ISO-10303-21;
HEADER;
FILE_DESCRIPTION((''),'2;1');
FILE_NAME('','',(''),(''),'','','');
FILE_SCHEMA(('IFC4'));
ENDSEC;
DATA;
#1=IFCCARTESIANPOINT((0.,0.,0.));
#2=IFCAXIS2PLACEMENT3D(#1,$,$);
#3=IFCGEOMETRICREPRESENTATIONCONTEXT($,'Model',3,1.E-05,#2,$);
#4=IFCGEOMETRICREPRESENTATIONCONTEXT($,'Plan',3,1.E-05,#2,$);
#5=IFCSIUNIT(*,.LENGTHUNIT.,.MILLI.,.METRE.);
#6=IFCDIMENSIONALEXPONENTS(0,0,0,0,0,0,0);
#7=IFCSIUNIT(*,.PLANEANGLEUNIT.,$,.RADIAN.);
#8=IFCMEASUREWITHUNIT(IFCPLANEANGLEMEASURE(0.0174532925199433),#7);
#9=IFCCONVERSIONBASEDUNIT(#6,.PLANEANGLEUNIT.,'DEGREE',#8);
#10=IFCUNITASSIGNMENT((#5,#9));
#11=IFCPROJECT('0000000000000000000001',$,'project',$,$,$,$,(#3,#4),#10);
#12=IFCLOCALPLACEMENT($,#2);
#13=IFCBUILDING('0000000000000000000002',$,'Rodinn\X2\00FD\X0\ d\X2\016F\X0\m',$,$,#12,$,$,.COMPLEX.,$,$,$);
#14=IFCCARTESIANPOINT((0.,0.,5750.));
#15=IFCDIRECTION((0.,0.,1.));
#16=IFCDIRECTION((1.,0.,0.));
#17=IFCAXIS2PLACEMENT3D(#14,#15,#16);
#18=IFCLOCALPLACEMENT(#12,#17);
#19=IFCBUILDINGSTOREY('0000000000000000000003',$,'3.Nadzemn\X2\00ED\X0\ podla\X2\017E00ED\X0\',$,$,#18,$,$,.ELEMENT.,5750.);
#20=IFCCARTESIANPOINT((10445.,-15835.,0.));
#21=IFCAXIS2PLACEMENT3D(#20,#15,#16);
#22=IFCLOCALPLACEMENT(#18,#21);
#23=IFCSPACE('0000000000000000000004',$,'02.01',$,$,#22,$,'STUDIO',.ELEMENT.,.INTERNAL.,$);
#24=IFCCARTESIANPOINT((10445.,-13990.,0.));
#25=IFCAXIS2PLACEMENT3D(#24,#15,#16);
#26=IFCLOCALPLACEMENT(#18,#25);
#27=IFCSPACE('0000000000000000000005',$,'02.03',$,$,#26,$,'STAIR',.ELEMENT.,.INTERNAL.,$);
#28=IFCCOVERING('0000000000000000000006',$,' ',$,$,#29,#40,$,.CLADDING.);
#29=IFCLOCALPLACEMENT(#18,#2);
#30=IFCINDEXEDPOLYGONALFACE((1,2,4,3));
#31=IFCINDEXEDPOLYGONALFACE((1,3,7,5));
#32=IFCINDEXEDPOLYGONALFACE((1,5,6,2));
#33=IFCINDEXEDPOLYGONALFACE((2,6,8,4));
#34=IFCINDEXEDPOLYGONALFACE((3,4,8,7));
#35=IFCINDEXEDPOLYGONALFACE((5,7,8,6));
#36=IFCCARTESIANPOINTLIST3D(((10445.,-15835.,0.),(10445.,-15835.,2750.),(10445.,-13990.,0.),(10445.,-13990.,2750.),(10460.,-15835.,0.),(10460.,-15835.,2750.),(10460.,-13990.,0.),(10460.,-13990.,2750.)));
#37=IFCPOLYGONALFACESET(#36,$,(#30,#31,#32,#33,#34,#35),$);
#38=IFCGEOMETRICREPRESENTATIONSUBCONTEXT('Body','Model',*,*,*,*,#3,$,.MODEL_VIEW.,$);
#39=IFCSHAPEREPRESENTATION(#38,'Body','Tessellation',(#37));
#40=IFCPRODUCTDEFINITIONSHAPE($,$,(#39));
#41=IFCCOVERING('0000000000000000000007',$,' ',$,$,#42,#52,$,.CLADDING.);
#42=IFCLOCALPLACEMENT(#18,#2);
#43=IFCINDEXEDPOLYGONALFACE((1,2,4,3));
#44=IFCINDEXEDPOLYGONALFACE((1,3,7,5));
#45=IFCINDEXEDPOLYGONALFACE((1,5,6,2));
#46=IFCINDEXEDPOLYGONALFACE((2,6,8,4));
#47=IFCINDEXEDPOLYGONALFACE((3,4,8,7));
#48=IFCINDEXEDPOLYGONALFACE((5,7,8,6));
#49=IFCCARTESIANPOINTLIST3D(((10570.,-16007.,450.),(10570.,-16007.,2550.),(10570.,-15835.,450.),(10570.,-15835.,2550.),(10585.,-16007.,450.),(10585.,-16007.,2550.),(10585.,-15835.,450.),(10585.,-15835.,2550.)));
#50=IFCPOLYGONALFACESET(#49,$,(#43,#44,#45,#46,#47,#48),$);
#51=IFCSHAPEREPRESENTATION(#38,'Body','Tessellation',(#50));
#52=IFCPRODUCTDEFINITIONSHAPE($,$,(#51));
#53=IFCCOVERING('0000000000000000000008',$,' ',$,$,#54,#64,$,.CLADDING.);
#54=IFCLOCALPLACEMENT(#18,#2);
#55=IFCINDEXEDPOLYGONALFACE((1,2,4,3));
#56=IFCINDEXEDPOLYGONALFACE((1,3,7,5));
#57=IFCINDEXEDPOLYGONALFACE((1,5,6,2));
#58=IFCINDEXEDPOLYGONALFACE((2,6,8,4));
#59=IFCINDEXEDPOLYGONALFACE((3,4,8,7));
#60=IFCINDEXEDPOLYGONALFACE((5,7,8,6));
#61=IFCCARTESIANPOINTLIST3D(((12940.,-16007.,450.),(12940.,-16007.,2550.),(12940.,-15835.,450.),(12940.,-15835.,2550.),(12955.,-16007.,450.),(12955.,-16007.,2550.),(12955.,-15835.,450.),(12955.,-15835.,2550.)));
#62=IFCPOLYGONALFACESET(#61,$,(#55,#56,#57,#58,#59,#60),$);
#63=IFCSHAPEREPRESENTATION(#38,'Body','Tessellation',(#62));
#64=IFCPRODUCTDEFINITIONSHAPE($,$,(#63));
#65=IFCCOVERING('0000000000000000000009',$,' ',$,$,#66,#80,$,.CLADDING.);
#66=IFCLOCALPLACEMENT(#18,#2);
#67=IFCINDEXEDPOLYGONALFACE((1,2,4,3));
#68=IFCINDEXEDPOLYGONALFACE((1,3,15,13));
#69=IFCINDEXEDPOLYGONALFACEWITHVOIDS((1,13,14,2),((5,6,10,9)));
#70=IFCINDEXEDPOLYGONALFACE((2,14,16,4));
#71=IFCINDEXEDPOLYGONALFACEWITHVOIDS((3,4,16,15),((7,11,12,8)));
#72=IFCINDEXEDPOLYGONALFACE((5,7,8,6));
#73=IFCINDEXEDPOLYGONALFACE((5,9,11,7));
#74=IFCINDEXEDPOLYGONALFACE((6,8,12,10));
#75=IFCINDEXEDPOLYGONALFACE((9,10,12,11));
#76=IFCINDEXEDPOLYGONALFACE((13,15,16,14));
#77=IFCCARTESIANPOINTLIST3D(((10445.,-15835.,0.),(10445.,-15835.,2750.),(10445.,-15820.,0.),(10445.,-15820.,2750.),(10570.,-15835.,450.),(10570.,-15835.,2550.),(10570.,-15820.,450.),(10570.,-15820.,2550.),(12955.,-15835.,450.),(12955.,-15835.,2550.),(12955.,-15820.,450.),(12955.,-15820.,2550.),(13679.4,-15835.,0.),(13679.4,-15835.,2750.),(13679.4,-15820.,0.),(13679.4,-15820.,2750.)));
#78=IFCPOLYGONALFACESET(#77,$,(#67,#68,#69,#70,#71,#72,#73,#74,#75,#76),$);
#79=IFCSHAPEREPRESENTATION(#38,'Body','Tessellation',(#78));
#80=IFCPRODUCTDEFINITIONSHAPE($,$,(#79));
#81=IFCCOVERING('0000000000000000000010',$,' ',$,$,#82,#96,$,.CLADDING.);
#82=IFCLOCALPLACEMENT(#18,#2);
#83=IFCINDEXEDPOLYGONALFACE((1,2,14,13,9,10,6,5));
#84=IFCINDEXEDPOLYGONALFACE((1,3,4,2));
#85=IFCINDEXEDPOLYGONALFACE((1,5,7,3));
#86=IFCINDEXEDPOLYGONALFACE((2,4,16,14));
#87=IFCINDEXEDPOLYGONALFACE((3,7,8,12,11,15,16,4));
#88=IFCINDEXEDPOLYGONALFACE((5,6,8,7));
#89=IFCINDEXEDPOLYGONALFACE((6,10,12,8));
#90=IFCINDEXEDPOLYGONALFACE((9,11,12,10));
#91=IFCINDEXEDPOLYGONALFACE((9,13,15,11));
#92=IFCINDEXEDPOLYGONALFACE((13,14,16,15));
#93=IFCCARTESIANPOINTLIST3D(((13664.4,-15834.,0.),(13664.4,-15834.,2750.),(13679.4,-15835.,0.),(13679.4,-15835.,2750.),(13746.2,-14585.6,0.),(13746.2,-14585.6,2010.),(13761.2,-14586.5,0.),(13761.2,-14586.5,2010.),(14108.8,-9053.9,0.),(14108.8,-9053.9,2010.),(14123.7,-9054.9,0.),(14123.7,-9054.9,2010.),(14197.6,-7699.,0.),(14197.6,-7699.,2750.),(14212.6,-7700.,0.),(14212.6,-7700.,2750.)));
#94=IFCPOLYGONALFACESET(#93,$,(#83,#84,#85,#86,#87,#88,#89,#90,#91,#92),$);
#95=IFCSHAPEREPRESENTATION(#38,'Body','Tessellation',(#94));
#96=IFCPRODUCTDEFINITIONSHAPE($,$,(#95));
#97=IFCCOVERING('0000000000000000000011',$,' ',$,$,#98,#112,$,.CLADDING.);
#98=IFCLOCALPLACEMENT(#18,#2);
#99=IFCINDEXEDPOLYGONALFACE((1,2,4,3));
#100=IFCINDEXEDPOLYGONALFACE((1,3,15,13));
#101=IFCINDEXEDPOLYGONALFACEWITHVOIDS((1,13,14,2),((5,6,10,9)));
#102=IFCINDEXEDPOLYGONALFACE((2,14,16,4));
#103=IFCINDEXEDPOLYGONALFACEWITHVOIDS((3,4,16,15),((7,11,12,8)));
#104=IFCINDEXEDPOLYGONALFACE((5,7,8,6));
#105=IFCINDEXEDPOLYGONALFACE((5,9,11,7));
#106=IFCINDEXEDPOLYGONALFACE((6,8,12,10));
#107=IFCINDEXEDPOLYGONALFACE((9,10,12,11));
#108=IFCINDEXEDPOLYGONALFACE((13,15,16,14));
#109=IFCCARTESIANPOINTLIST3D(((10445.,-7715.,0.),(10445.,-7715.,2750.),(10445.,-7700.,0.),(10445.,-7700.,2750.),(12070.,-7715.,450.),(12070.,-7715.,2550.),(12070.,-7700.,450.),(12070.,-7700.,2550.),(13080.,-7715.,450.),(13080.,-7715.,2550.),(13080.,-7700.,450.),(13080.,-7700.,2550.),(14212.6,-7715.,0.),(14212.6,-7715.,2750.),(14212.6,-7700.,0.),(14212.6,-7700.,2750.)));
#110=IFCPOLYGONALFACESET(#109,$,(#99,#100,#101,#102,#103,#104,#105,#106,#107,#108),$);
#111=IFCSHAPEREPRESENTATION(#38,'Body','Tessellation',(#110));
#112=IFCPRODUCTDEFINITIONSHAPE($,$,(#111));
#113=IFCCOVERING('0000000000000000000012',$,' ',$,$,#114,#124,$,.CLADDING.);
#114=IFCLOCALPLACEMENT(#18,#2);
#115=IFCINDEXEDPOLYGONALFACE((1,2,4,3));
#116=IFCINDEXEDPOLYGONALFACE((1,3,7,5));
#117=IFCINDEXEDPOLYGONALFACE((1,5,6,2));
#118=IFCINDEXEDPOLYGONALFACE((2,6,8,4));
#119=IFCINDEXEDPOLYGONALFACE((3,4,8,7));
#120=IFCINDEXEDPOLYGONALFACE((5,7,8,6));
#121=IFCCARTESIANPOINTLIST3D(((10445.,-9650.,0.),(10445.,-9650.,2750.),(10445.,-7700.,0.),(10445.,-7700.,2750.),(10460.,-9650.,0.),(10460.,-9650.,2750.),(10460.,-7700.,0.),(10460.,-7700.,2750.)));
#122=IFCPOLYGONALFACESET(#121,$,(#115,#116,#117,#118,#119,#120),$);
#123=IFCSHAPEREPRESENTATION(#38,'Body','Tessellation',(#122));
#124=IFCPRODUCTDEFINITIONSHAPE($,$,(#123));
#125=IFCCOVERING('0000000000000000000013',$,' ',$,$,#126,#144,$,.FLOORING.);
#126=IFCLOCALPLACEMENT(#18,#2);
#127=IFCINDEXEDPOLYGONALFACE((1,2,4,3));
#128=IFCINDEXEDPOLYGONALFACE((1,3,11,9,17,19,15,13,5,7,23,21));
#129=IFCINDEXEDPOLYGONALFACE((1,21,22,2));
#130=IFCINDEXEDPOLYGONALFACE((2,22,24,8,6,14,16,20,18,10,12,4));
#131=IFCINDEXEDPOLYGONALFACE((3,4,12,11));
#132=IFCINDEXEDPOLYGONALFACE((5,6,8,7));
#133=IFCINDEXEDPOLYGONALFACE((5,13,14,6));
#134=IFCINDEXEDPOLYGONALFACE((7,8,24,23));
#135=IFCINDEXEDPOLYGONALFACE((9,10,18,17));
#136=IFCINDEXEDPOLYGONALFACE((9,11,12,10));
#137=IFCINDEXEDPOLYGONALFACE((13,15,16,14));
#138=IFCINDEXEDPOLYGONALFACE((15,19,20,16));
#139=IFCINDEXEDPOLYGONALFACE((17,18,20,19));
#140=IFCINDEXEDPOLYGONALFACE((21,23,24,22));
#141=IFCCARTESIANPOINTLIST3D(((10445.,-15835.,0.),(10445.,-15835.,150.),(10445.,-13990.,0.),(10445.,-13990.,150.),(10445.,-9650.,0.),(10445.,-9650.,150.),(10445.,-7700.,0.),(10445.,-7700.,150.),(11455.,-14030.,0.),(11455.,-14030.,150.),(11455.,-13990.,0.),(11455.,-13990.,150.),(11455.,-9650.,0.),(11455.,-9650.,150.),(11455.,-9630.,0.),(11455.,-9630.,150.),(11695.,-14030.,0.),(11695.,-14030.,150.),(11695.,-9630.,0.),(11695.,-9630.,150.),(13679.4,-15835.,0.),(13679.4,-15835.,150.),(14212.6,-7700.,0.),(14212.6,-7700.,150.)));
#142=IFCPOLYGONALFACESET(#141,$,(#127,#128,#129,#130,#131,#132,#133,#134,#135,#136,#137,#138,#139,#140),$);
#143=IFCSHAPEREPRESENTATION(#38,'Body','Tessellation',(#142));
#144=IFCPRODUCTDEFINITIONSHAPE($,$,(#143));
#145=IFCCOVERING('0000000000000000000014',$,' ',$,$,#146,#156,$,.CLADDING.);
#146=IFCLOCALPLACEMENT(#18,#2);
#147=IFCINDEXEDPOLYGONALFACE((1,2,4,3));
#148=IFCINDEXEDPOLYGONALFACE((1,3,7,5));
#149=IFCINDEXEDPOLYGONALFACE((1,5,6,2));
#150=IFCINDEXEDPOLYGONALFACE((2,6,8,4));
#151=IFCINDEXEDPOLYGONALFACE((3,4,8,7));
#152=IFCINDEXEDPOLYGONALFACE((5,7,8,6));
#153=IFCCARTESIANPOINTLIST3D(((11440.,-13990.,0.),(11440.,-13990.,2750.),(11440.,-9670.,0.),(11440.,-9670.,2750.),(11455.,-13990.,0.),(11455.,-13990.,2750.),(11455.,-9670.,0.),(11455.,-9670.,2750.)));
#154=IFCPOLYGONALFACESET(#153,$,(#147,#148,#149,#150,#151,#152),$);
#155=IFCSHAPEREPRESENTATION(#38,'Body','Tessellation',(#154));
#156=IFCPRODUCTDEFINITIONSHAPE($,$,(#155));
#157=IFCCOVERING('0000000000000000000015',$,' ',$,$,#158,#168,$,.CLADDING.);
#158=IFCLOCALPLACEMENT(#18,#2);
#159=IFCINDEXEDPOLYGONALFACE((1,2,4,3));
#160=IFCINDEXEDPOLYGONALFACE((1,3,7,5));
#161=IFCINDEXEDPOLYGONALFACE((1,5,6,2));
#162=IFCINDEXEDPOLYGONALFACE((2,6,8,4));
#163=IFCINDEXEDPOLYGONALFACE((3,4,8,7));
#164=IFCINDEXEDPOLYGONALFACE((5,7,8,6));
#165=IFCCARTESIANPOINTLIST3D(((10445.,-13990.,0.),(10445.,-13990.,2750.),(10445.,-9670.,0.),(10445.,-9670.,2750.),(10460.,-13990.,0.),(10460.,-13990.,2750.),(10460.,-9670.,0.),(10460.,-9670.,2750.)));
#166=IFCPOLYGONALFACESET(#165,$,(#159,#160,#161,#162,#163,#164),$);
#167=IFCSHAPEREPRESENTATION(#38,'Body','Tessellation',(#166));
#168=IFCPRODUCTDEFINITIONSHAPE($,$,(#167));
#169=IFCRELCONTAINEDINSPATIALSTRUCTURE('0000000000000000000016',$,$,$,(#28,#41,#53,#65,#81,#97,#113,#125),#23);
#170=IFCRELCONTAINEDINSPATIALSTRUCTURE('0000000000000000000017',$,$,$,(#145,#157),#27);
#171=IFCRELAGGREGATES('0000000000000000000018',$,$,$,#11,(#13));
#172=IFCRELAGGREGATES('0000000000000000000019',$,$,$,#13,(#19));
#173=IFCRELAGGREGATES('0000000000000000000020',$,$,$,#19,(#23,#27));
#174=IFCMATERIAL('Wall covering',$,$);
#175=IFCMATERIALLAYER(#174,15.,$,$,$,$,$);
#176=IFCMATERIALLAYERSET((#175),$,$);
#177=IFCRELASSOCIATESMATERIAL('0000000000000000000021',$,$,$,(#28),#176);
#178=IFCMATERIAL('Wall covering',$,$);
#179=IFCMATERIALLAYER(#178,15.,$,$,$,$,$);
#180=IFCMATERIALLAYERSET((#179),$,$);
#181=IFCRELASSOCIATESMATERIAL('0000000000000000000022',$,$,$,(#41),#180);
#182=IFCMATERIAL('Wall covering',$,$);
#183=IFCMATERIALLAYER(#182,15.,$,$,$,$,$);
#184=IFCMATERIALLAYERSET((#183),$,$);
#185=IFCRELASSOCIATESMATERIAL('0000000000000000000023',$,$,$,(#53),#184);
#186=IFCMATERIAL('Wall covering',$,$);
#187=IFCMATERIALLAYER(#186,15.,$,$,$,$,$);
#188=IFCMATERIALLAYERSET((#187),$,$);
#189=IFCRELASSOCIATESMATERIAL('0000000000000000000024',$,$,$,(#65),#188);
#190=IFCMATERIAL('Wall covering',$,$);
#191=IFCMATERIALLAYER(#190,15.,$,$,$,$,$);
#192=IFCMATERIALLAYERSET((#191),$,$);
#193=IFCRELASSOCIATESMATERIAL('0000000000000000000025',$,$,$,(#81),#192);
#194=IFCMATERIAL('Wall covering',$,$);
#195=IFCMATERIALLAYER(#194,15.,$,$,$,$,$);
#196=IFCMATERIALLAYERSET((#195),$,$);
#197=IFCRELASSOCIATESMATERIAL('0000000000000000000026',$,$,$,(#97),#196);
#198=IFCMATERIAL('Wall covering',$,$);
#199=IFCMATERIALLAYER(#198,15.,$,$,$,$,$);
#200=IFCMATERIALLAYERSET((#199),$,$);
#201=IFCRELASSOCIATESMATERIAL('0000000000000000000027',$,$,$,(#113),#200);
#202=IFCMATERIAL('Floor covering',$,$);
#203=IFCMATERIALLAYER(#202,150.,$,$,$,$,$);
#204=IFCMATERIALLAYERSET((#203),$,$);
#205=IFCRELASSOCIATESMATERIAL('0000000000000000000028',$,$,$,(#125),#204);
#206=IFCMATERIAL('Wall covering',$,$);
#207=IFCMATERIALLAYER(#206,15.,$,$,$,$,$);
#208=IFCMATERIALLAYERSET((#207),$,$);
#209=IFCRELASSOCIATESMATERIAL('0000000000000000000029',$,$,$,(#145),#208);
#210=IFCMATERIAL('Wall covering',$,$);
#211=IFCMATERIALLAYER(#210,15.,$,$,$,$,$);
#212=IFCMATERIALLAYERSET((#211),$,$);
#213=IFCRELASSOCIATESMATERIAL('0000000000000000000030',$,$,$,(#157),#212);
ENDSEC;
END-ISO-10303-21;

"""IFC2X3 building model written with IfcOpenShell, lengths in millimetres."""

from ifc_helpers import new_model, entity, si_unit, converted_unit, frame, frame_2d, origin, origin_with_axes, place, context, subcontext, project, spatial, polyline, rectangle, outline, extrude, material, layer, layer_set, layer_usage, element, save


model = new_model("IFC2X3")

# Units and contexts
model_context = context("Model", 3, precision=1e-05, world=origin())
plan_context = context("Plan", 3, precision=1e-05, world=origin())
body_context = subcontext(model_context, "Body", "Model", "MODEL_VIEW")
ifc_project = project(units=[si_unit("LENGTHUNIT", "METRE", prefix="MILLI"), converted_unit("PLANEANGLEUNIT", "DEGREE", entity("IfcPlaneAngleMeasure", 0.0174532925199433), si_unit("PLANEANGLEUNIT", "RADIAN"), dimensions=[0, 0, 0, 0, 0, 0, 0])], contexts=[model_context, plan_context])

# Building, storey
building_placement = place(None, origin())
building = spatial("IfcBuilding", under=ifc_project, at=building_placement, Name="Rodinný dům", CompositionType="COMPLEX")
storey_placement = place(building_placement, frame((0.0, 0.0, 5750.0), z_axis=(0.0, 0.0, 1.0), x_axis=(1.0, 0.0, 0.0)))
storey = spatial("IfcBuildingStorey", under=building, at=storey_placement, Name="3.Nadzemní podlaží", CompositionType="ELEMENT", Elevation=5750.0)

# Shared definitions
space_1_placement = place(storey_placement, frame((10445.0, -15835.0, 0.0), z_axis=(0.0, 0.0, 1.0), x_axis=(1.0, 0.0, 0.0)))
space_1 = spatial("IfcSpace", under=storey, at=space_1_placement, Name="02.01", LongName="STUDIO", CompositionType="ELEMENT", InteriorOrExteriorSpace="INTERNAL")

# Coverings
ifc_material_1 = material(Name="Wall covering")
ifc_layer_1 = layer(ifc_material_1, 15.0)
ifc_layer_set_1 = layer_set([ifc_layer_1])
ifc_layer_usage_1 = layer_usage(ifc_layer_set_1, "AXIS3", "POSITIVE", 0.0)
covering_1_placement = place(space_1_placement, frame((0.0, 1845.0, 0.0), z_axis=(0.0, 0.0, 1.0), x_axis=(0.0, -1.0, 0.0)))
element("IfcCovering", 1, at=covering_1_placement, inside=space_1, material=ifc_layer_usage_1, Name=" ", PredefinedType="CLADDING", context=body_context, shape_type="SweptSolid", body=[
    extrude(rectangle(XDim=2750.0, YDim=1845.0, at=frame_2d((-922.5, 1375.0), x_axis=(0.0, 1.0))), frame((1845.0, 0.0, 2750.0), z_axis=(0.0, 1.0, 0.0), x_axis=(1.0, 0.0, 0.0)), (0.0, 0.0, 1.0), 15.0),
])
ifc_material_2 = material(Name="Wall covering")
ifc_layer_2 = layer(ifc_material_2, 15.0)
ifc_layer_set_2 = layer_set([ifc_layer_2])
ifc_layer_usage_2 = layer_usage(ifc_layer_set_2, "AXIS3", "POSITIVE", 0.0)
covering_2_placement = place(space_1_placement, frame((125.0, 0.0, 450.0), z_axis=(0.0, 0.0, 1.0), x_axis=(0.0, -1.0, 0.0)))
element("IfcCovering", 2, at=covering_2_placement, inside=space_1, material=ifc_layer_usage_2, Name=" ", PredefinedType="CLADDING", context=body_context, shape_type="SweptSolid", body=[
    extrude(rectangle(XDim=2100.0, YDim=172.0, at=frame_2d((-86.0, 1050.0), x_axis=(0.0, 1.0))), frame((172.0, 0.0, 2100.0), z_axis=(0.0, 1.0, 0.0), x_axis=(1.0, 0.0, 0.0)), (0.0, 0.0, 1.0), 15.0),
])
ifc_material_3 = material(Name="Wall covering")
ifc_layer_3 = layer(ifc_material_3, 15.0)
ifc_layer_set_3 = layer_set([ifc_layer_3])
ifc_layer_usage_3 = layer_usage(ifc_layer_set_3, "AXIS3", "POSITIVE", 0.0)
covering_3_placement = place(space_1_placement, frame((2510.0, -172.0, 450.0), z_axis=(0.0, 0.0, 1.0), x_axis=(0.0, 1.0, 0.0)))
element("IfcCovering", 3, at=covering_3_placement, inside=space_1, material=ifc_layer_usage_3, Name=" ", PredefinedType="CLADDING", context=body_context, shape_type="SweptSolid", body=[
    extrude(rectangle(XDim=2100.0, YDim=172.0, at=frame_2d((-86.0, 1050.0), x_axis=(0.0, 1.0))), frame((172.0, 0.0, 2100.0), z_axis=(0.0, 1.0, 0.0), x_axis=(1.0, 0.0, 0.0)), (0.0, 0.0, 1.0), 15.0),
])
ifc_material_4 = material(Name="Wall covering")
ifc_layer_4 = layer(ifc_material_4, 15.0)
ifc_layer_set_4 = layer_set([ifc_layer_4])
ifc_layer_usage_4 = layer_usage(ifc_layer_set_4, "AXIS3", "POSITIVE", 0.0)
covering_4_placement = place(space_1_placement, origin_with_axes())
element("IfcCovering", 4, at=covering_4_placement, inside=space_1, material=ifc_layer_usage_4, Name=" ", PredefinedType="CLADDING", context=body_context, shape_type="SweptSolid", body=[
    extrude(outline(polyline([(3234.4, 0.0), (3234.4, -2750.0), (0.0, -2750.0), (0.0, 0.0), (3234.4, 0.0)]), holes=[polyline([(2510.0, -450.0), (125.0, -450.0), (125.0, -2550.0), (2510.0, -2550.0), (2510.0, -450.0)])]), frame((0.0, 0.0, 0.0), z_axis=(0.0, 1.0, 0.0), x_axis=(1.0, 0.0, 0.0)), (0.0, 0.0, 1.0), 15.0),
])
ifc_material_5 = material(Name="Wall covering")
ifc_layer_5 = layer(ifc_material_5, 15.0)
ifc_layer_set_5 = layer_set([ifc_layer_5])
ifc_layer_usage_5 = layer_usage(ifc_layer_set_5, "AXIS3", "POSITIVE", 0.0)
covering_5_placement = place(space_1_placement, frame((3234.4, 0.0, 0.0), z_axis=(0.0, 0.0, 1.0), x_axis=(0.065403, 0.997859, 0.0)))
element("IfcCovering", 5, at=covering_5_placement, inside=space_1, material=ifc_layer_usage_5, Name=" ", PredefinedType="CLADDING", context=body_context, shape_type="SweptSolid", body=[
    extrude(outline(polyline([(8152.5, 0.0), (8152.5, -2750.0), (0.0, -2750.0), (0.0, 0.0), (1251.1, 0.0), (1251.1, -2010.0), (6794.6, -2010.0), (6794.6, 0.0), (8152.5, 0.0)])), frame((0.0, 0.0, 0.0), z_axis=(0.0, 1.0, 0.0), x_axis=(1.0, 0.0, 0.0)), (0.0, 0.0, 1.0), 15.0),
])
ifc_material_6 = material(Name="Wall covering")
ifc_layer_6 = layer(ifc_material_6, 15.0)
ifc_layer_set_6 = layer_set([ifc_layer_6])
ifc_layer_usage_6 = layer_usage(ifc_layer_set_6, "AXIS3", "POSITIVE", 0.0)
covering_6_placement = place(space_1_placement, frame((3767.6, 8135.0, 0.0), z_axis=(0.0, 0.0, 1.0), x_axis=(-1.0, 0.0, 0.0)))
element("IfcCovering", 6, at=covering_6_placement, inside=space_1, material=ifc_layer_usage_6, Name=" ", PredefinedType="CLADDING", context=body_context, shape_type="SweptSolid", body=[
    extrude(outline(polyline([(3767.6, 0.0), (3767.6, -2750.0), (0.0, -2750.0), (0.0, 0.0), (3767.6, 0.0)]), holes=[polyline([(2142.6, -450.0), (1132.6, -450.0), (1132.6, -2550.0), (2142.6, -2550.0), (2142.6, -450.0)])]), frame((0.0, 0.0, 0.0), z_axis=(0.0, 1.0, 0.0), x_axis=(1.0, 0.0, 0.0)), (0.0, 0.0, 1.0), 15.0),
])
ifc_material_7 = material(Name="Wall covering")
ifc_layer_7 = layer(ifc_material_7, 15.0)
ifc_layer_set_7 = layer_set([ifc_layer_7])
ifc_layer_usage_7 = layer_usage(ifc_layer_set_7, "AXIS3", "POSITIVE", 0.0)
covering_7_placement = place(space_1_placement, frame((0.0, 8135.0, 0.0), z_axis=(0.0, 0.0, 1.0), x_axis=(0.0, -1.0, 0.0)))
element("IfcCovering", 7, at=covering_7_placement, inside=space_1, material=ifc_layer_usage_7, Name=" ", PredefinedType="CLADDING", context=body_context, shape_type="SweptSolid", body=[
    extrude(rectangle(XDim=2750.0, YDim=1950.0, at=frame_2d((-975.0, 1375.0), x_axis=(0.0, 1.0))), frame((1950.0, 0.0, 2750.0), z_axis=(0.0, 1.0, 0.0), x_axis=(1.0, 0.0, 0.0)), (0.0, 0.0, 1.0), 15.0),
])
ifc_material_8 = material(Name="Floor covering")
ifc_layer_8 = layer(ifc_material_8, 150.0)
ifc_layer_set_8 = layer_set([ifc_layer_8])
ifc_layer_usage_8 = layer_usage(ifc_layer_set_8, "AXIS3", "POSITIVE", 0.0)
covering_8_placement = place(space_1_placement, origin_with_axes())
element("IfcCovering", 8, at=covering_8_placement, inside=space_1, material=ifc_layer_usage_8, Name=" ", PredefinedType="FLOORING", context=body_context, shape_type="SweptSolid", body=[
    extrude(outline(polyline([(1250.0, 6205.0), (1250.0, 1805.0), (1010.0, 1805.0), (1010.0, 1845.0), (0.0, 1845.0), (0.0, 0.0), (3234.4, 0.0), (3767.6, 8135.0), (0.0, 8135.0), (0.0, 6185.0), (1010.0, 6185.0), (1010.0, 6205.0), (1250.0, 6205.0)])), origin_with_axes(), (0.0, 0.0, 1.0), 150.0),
])

# Shared definitions
space_2_placement = place(storey_placement, frame((10445.0, -13990.0, 0.0), z_axis=(0.0, 0.0, 1.0), x_axis=(1.0, 0.0, 0.0)))
space_2 = spatial("IfcSpace", under=storey, at=space_2_placement, Name="02.03", LongName="STAIR", CompositionType="ELEMENT", InteriorOrExteriorSpace="INTERNAL")

# Coverings
ifc_material_9 = material(Name="Wall covering")
ifc_layer_9 = layer(ifc_material_9, 15.0)
ifc_layer_set_9 = layer_set([ifc_layer_9])
ifc_layer_usage_9 = layer_usage(ifc_layer_set_9, "AXIS3", "POSITIVE", 0.0)
covering_9_placement = place(space_2_placement, frame((1010.0, 0.0, 0.0), z_axis=(0.0, 0.0, 1.0), x_axis=(0.0, 1.0, 0.0)))
element("IfcCovering", 9, at=covering_9_placement, inside=space_2, material=ifc_layer_usage_9, Name=" ", PredefinedType="CLADDING", context=body_context, shape_type="SweptSolid", body=[
    extrude(rectangle(XDim=2750.0, YDim=4320.0, at=frame_2d((-2160.0, 1375.0), x_axis=(0.0, 1.0))), frame((4320.0, 0.0, 2750.0), z_axis=(0.0, 1.0, 0.0), x_axis=(1.0, 0.0, 0.0)), (0.0, 0.0, 1.0), 15.0),
])
ifc_material_10 = material(Name="Wall covering")
ifc_layer_10 = layer(ifc_material_10, 15.0)
ifc_layer_set_10 = layer_set([ifc_layer_10])
ifc_layer_usage_10 = layer_usage(ifc_layer_set_10, "AXIS3", "POSITIVE", 0.0)
covering_10_placement = place(space_2_placement, frame((0.0, 4320.0, 0.0), z_axis=(0.0, 0.0, 1.0), x_axis=(0.0, -1.0, 0.0)))
element("IfcCovering", 10, at=covering_10_placement, inside=space_2, material=ifc_layer_usage_10, Name=" ", PredefinedType="CLADDING", context=body_context, shape_type="SweptSolid", body=[
    extrude(rectangle(XDim=2750.0, YDim=4320.0, at=frame_2d((-2160.0, 1375.0), x_axis=(0.0, 1.0))), frame((4320.0, 0.0, 2750.0), z_axis=(0.0, 1.0, 0.0), x_axis=(1.0, 0.0, 0.0)), (0.0, 0.0, 1.0), 15.0),
])

save(model, "model.ifc")
